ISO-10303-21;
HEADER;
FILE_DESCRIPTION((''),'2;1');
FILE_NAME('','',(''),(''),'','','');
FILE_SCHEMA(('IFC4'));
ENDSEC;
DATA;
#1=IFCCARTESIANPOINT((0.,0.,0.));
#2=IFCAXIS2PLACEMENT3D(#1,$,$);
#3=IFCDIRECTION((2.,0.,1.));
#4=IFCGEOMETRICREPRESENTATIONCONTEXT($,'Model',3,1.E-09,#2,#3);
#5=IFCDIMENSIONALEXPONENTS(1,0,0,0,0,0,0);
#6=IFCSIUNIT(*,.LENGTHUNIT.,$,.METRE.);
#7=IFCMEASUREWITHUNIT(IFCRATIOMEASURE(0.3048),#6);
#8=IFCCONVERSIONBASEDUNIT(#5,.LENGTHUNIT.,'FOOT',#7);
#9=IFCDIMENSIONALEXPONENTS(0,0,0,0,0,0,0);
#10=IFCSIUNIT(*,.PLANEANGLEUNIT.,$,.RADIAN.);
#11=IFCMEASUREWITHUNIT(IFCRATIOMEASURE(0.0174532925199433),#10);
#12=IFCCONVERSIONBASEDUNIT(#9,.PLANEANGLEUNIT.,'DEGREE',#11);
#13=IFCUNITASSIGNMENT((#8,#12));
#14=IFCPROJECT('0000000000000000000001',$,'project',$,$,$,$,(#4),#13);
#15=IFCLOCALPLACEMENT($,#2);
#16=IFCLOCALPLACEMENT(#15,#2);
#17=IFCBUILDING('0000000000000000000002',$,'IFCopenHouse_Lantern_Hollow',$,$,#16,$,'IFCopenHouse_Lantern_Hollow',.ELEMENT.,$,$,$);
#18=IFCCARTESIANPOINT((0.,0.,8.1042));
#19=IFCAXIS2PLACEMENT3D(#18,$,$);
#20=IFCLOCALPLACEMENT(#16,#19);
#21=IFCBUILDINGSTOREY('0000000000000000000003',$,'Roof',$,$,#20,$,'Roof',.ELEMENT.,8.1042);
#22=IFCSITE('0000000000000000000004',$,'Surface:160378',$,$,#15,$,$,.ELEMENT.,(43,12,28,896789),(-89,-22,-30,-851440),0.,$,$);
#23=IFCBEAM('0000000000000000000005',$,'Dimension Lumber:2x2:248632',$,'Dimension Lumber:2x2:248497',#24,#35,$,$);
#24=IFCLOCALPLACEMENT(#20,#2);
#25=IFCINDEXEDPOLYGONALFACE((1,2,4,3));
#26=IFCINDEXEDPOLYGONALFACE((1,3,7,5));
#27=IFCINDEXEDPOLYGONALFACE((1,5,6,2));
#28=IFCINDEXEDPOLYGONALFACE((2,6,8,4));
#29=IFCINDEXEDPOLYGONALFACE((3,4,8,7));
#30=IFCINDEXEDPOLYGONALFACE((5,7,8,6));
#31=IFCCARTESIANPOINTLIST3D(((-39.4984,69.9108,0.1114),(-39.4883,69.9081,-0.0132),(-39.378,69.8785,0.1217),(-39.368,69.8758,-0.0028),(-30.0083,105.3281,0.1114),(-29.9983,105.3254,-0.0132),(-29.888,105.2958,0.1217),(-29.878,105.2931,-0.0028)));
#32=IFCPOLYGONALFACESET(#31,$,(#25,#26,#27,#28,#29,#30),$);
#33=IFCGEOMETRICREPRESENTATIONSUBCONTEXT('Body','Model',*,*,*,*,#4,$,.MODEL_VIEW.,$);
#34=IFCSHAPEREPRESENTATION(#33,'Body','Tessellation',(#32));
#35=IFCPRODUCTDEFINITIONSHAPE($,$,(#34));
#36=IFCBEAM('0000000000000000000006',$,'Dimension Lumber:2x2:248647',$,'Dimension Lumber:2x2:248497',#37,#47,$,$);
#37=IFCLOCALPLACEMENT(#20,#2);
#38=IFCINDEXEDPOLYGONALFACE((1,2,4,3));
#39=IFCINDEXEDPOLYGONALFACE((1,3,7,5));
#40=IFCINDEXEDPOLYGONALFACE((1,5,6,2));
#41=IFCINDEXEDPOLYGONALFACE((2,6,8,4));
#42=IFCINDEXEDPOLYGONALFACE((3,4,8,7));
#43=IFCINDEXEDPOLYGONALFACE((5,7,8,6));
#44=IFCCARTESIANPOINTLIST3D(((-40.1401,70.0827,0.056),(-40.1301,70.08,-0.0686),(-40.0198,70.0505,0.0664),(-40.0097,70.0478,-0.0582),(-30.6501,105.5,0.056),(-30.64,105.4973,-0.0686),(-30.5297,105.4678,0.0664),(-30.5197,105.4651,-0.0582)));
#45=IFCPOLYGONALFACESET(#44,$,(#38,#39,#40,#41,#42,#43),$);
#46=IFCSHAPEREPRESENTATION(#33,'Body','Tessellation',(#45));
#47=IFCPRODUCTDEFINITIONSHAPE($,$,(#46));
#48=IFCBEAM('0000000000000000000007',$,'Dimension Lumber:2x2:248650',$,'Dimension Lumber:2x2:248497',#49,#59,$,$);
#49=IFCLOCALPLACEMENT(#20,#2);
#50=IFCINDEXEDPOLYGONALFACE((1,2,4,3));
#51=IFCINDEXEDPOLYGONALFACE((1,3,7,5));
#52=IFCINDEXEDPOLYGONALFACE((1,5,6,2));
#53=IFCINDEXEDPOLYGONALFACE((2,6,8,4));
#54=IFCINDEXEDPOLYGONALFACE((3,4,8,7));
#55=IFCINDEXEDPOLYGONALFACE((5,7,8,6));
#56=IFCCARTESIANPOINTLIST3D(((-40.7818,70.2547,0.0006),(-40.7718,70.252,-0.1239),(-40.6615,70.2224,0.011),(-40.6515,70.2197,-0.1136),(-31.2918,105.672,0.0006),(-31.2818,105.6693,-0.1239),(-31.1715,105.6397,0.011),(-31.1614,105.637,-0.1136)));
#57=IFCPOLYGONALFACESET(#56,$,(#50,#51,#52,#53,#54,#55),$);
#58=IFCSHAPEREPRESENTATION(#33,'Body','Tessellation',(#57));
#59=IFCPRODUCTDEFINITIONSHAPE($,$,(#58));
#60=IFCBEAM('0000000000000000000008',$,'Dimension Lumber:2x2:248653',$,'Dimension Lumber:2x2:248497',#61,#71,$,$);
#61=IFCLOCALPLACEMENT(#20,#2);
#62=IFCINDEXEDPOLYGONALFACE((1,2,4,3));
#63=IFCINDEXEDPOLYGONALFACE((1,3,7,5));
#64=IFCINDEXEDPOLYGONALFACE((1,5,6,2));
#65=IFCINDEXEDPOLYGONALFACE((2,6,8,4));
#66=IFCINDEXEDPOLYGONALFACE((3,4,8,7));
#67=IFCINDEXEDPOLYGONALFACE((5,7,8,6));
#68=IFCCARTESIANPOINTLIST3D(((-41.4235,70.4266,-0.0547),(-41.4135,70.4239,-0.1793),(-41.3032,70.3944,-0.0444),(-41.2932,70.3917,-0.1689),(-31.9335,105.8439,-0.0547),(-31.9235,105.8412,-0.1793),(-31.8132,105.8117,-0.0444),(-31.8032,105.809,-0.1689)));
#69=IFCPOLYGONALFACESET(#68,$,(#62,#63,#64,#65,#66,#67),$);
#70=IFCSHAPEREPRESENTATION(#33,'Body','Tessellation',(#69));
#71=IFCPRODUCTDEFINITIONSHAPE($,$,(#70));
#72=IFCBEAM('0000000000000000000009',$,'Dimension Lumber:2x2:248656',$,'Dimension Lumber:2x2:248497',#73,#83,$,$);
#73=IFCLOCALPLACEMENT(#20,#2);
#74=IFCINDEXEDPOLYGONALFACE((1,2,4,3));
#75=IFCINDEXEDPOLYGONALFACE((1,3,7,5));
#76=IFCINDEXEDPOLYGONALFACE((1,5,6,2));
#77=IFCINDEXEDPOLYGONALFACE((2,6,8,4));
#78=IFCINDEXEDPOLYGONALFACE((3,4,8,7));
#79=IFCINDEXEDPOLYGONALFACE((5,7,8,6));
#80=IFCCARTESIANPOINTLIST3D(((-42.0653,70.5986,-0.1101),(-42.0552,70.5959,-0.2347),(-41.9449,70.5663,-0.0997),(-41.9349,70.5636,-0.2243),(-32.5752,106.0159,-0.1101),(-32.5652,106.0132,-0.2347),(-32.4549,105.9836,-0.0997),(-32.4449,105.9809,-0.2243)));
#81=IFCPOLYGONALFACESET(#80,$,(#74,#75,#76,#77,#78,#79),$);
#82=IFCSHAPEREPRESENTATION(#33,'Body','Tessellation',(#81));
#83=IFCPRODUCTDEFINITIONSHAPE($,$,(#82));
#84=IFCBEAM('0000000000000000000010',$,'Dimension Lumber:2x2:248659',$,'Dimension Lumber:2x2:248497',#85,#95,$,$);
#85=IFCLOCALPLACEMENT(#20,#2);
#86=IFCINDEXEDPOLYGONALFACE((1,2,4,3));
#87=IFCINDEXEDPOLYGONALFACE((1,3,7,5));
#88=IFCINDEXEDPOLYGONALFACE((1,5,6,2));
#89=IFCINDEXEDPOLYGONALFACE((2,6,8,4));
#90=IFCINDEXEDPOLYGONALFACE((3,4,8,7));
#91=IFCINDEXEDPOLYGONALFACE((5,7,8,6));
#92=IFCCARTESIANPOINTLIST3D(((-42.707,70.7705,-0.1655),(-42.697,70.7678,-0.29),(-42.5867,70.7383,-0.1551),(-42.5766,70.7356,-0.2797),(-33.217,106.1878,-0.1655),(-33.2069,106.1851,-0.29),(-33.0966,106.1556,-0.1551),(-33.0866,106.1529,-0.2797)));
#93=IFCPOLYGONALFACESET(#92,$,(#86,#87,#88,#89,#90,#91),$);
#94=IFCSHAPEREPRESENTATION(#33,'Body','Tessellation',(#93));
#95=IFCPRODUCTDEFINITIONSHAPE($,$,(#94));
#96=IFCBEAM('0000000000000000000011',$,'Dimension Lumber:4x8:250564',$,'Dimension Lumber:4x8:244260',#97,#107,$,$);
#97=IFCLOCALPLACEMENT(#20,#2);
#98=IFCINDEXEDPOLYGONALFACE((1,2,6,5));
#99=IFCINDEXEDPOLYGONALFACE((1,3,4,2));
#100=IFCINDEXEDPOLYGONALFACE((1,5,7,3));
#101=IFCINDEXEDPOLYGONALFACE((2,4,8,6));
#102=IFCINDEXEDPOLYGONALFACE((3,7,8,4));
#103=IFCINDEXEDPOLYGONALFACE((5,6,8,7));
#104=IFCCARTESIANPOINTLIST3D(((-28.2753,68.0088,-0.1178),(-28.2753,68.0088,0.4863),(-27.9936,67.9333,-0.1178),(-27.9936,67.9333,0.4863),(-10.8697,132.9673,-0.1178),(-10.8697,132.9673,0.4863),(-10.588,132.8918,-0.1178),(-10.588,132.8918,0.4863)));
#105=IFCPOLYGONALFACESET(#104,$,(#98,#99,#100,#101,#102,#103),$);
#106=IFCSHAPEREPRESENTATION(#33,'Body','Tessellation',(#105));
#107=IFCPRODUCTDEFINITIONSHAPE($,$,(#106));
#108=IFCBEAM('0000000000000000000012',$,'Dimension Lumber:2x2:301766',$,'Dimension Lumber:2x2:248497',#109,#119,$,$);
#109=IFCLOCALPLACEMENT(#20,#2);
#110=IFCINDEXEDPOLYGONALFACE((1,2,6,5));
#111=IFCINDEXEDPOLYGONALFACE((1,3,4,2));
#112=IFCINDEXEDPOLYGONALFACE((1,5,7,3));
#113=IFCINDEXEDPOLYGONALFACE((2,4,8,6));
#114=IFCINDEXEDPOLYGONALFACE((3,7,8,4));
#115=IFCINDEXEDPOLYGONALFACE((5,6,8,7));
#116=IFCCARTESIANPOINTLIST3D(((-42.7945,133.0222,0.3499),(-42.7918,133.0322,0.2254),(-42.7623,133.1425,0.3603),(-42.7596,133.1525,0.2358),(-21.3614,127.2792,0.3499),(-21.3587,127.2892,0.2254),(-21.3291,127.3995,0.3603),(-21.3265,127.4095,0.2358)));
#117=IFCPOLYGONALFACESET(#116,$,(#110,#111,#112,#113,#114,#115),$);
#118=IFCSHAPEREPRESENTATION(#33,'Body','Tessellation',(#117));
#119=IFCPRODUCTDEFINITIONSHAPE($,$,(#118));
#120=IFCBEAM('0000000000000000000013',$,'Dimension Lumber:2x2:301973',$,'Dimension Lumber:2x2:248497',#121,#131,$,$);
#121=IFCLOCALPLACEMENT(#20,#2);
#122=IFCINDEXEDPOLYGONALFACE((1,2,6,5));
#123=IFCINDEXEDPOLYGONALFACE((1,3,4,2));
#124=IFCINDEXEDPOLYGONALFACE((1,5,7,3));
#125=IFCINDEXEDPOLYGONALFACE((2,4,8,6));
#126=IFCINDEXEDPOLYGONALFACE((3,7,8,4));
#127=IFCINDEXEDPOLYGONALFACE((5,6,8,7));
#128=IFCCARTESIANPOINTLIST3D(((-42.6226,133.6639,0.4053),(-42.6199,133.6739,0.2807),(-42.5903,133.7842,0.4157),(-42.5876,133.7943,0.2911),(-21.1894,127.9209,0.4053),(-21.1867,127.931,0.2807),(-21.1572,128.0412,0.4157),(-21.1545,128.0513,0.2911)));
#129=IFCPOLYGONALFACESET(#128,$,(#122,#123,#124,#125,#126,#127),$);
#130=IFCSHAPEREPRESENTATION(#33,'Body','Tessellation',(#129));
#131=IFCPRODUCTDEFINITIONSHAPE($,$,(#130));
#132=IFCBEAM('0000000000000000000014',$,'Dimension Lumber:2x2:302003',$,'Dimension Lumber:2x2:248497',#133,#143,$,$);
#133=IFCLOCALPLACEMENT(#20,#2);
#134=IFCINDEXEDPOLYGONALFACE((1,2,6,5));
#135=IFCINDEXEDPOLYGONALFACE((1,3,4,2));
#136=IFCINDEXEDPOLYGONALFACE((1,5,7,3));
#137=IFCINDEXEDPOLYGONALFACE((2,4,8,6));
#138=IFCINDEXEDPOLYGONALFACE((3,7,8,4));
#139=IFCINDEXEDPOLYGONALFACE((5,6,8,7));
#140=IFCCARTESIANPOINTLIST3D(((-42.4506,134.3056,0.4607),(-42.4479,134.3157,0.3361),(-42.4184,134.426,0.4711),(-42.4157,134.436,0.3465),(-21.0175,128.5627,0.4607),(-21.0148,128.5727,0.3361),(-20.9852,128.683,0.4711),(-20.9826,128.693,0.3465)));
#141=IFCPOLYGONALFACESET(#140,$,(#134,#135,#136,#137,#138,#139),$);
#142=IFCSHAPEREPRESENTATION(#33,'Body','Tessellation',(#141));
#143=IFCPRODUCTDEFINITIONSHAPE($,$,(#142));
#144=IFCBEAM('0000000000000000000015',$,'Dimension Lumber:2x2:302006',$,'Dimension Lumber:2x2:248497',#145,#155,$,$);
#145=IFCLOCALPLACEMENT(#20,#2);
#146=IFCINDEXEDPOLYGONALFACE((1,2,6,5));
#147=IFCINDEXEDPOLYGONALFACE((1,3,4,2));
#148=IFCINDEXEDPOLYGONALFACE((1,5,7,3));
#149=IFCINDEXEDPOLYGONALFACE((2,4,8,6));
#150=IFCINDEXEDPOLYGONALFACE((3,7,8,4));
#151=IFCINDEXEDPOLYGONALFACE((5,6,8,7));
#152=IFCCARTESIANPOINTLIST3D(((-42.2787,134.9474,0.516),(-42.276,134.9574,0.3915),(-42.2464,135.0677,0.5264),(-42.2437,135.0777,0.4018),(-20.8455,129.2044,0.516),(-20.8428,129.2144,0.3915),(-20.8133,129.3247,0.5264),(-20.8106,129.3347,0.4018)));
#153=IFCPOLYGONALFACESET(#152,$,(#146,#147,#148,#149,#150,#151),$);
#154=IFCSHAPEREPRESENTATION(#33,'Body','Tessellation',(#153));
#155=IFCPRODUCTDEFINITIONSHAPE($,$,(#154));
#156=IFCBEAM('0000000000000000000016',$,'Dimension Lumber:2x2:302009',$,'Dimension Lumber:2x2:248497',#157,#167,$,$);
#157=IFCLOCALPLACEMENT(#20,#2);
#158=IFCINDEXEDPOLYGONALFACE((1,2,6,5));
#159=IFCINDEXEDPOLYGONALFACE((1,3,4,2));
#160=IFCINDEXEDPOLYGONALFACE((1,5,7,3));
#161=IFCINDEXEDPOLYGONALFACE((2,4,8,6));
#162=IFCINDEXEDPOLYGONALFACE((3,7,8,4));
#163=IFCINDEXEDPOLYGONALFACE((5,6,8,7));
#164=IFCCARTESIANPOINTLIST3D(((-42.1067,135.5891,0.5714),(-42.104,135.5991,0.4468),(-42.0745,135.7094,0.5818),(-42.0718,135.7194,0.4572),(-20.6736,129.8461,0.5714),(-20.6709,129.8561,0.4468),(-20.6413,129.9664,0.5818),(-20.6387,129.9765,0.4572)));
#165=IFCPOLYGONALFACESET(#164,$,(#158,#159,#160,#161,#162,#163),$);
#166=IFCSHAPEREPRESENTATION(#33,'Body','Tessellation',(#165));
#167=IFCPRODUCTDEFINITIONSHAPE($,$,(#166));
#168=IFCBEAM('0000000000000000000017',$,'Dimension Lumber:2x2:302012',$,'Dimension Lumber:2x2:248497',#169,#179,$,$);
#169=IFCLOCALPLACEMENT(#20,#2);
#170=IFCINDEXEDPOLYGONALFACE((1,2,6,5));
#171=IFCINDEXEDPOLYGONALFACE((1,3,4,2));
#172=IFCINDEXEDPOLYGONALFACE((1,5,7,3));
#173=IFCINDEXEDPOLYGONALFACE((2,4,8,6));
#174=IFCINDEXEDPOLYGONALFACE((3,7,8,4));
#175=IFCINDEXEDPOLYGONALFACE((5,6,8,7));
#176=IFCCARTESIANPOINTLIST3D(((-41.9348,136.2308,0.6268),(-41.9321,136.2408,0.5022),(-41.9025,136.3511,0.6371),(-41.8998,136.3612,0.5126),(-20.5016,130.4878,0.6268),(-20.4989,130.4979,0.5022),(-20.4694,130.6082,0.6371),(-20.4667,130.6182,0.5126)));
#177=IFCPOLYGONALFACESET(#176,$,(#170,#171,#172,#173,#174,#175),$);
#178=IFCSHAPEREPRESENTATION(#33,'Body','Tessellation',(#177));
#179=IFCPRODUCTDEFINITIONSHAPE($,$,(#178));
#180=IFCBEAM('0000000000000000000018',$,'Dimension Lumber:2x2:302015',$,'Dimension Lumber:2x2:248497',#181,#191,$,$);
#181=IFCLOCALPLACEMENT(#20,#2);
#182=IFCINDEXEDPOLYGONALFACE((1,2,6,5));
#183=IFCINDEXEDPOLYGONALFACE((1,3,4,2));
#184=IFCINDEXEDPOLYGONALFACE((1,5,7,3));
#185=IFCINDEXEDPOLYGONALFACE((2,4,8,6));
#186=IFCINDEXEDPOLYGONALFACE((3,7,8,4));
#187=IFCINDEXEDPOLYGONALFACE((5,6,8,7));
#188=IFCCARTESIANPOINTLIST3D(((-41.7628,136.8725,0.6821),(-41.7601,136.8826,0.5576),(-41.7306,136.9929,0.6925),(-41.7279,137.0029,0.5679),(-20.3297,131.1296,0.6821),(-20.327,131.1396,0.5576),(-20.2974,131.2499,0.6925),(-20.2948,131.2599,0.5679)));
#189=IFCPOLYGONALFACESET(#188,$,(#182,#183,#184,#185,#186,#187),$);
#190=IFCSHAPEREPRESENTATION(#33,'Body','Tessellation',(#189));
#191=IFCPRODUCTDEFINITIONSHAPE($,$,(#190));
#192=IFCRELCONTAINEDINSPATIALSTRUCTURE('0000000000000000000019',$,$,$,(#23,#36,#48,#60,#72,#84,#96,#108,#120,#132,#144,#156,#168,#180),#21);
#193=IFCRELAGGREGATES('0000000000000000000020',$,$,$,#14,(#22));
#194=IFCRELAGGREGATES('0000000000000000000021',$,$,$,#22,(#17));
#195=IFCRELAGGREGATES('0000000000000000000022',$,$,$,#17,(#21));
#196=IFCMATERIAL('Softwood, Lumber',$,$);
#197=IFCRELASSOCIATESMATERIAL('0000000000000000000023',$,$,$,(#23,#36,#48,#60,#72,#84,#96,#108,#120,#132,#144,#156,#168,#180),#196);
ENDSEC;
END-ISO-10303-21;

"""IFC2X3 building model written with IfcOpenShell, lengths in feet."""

from ifc_helpers import new_model, entity, si_unit, converted_unit, direction, frame, frame_2d, origin, place, context, subcontext, project, spatial, rectangle, extrude, material, element, save


model = new_model("IFC2X3")

# Units and contexts
model_context = context("Model", 3, precision=1e-09, world=origin(), true_north=direction((2.0, 0.0, 1.0)))
body_context = subcontext(model_context, "Body", "Model", "MODEL_VIEW")
ifc_project = project(units=[converted_unit("LENGTHUNIT", "FOOT", entity("IfcRatioMeasure", 0.3048), si_unit("LENGTHUNIT", "METRE"), dimensions=[1, 0, 0, 0, 0, 0, 0]), converted_unit("PLANEANGLEUNIT", "DEGREE", entity("IfcRatioMeasure", 0.0174532925199433), si_unit("PLANEANGLEUNIT", "RADIAN"), dimensions=[0, 0, 0, 0, 0, 0, 0])], contexts=[model_context])

# Site, building, storey
site_placement = place(None, origin())
site = spatial("IfcSite", under=ifc_project, at=site_placement, Name="Surface:160378", CompositionType="ELEMENT", RefLatitude=(43, 12, 28, 896789), RefLongitude=(-89, -22, -30, -851440), RefElevation=0.0)
building_placement = place(site_placement, origin())
building = spatial("IfcBuilding", under=site, at=building_placement, Name="IFCopenHouse_Lantern_Hollow", LongName="IFCopenHouse_Lantern_Hollow", CompositionType="ELEMENT")
storey_placement = place(building_placement, frame((0.0, 0.0, 8.1042)))
storey = spatial("IfcBuildingStorey", under=building, at=storey_placement, Name="Roof", LongName="Roof", CompositionType="ELEMENT", Elevation=8.1042)

# Beams
ifc_material_1 = material(Name="Softwood, Lumber")
beam_1_placement = place(storey_placement, frame((-39.4382, 69.8947, 0.1165), z_axis=(0.0, 0.0, 1.0), x_axis=(0.258819, 0.965926, 0.0)))
element("IfcBeam", 1, at=beam_1_placement, inside=storey, material=ifc_material_1, Name="Dimension Lumber:2x2:248632", ObjectType="Dimension Lumber:2x2:248497", context=body_context, shape_type="SweptSolid", body=[
    extrude(rectangle(XDim=0.125, YDim=0.125, at=frame_2d((0.0, 0.0), x_axis=(0.0, 1.0))), frame((0.0, -0.0052, -0.0623), z_axis=(1.0, 0.0, 0.0), x_axis=(0.0, -0.996546, 0.083045)), (0.0, 0.0, 1.0), 36.6667),
])
beam_2_placement = place(storey_placement, frame((-40.0799, 70.0666, 0.0612), z_axis=(0.0, 0.0, 1.0), x_axis=(0.258819, 0.965926, 0.0)))
element("IfcBeam", 2, at=beam_2_placement, inside=storey, material=ifc_material_1, Name="Dimension Lumber:2x2:248647", ObjectType="Dimension Lumber:2x2:248497", context=body_context, shape_type="SweptSolid", body=[
    extrude(rectangle(XDim=0.125, YDim=0.125, at=frame_2d((0.0, 0.0), x_axis=(0.0, 1.0))), frame((0.0, -0.0052, -0.0623), z_axis=(1.0, 0.0, 0.0), x_axis=(0.0, -0.996546, 0.083045)), (0.0, 0.0, 1.0), 36.6667),
])
beam_3_placement = place(storey_placement, frame((-40.7217, 70.2386, 0.0058), z_axis=(0.0, 0.0, 1.0), x_axis=(0.258819, 0.965926, 0.0)))
element("IfcBeam", 3, at=beam_3_placement, inside=storey, material=ifc_material_1, Name="Dimension Lumber:2x2:248650", ObjectType="Dimension Lumber:2x2:248497", context=body_context, shape_type="SweptSolid", body=[
    extrude(rectangle(XDim=0.125, YDim=0.125, at=frame_2d((0.0, 0.0), x_axis=(0.0, 1.0))), frame((0.0, -0.0052, -0.0623), z_axis=(1.0, 0.0, 0.0), x_axis=(0.0, -0.996546, 0.083045)), (0.0, 0.0, 1.0), 36.6667),
])
beam_4_placement = place(storey_placement, frame((-41.3634, 70.4105, -0.0495), z_axis=(0.0, 0.0, 1.0), x_axis=(0.258819, 0.965926, 0.0)))
element("IfcBeam", 4, at=beam_4_placement, inside=storey, material=ifc_material_1, Name="Dimension Lumber:2x2:248653", ObjectType="Dimension Lumber:2x2:248497", context=body_context, shape_type="SweptSolid", body=[
    extrude(rectangle(XDim=0.125, YDim=0.125, at=frame_2d((0.0, 0.0), x_axis=(0.0, 1.0))), frame((0.0, -0.0052, -0.0623), z_axis=(1.0, 0.0, 0.0), x_axis=(0.0, -0.996546, 0.083045)), (0.0, 0.0, 1.0), 36.6667),
])
beam_5_placement = place(storey_placement, frame((-42.0051, 70.5825, -0.1049), z_axis=(0.0, 0.0, 1.0), x_axis=(0.258819, 0.965926, 0.0)))
element("IfcBeam", 5, at=beam_5_placement, inside=storey, material=ifc_material_1, Name="Dimension Lumber:2x2:248656", ObjectType="Dimension Lumber:2x2:248497", context=body_context, shape_type="SweptSolid", body=[
    extrude(rectangle(XDim=0.125, YDim=0.125, at=frame_2d((0.0, 0.0), x_axis=(0.0, 1.0))), frame((0.0, -0.0052, -0.0623), z_axis=(1.0, 0.0, 0.0), x_axis=(0.0, -0.996546, 0.083045)), (0.0, 0.0, 1.0), 36.6667),
])
beam_6_placement = place(storey_placement, frame((-42.6468, 70.7544, -0.1603), z_axis=(0.0, 0.0, 1.0), x_axis=(0.258819, 0.965926, 0.0)))
element("IfcBeam", 6, at=beam_6_placement, inside=storey, material=ifc_material_1, Name="Dimension Lumber:2x2:248659", ObjectType="Dimension Lumber:2x2:248497", context=body_context, shape_type="SweptSolid", body=[
    extrude(rectangle(XDim=0.125, YDim=0.125, at=frame_2d((0.0, 0.0), x_axis=(0.0, 1.0))), frame((0.0, -0.0052, -0.0623), z_axis=(1.0, 0.0, 0.0), x_axis=(0.0, -0.996546, 0.083045)), (0.0, 0.0, 1.0), 36.6667),
])
beam_7_placement = place(storey_placement, frame((-10.7288, 132.9295, -0.1178), z_axis=(0.0, 0.0, 1.0), x_axis=(-0.258819, -0.965926, 0.0)))
element("IfcBeam", 7, at=beam_7_placement, inside=storey, material=ifc_material_1, Name="Dimension Lumber:4x8:250564", ObjectType="Dimension Lumber:4x8:244260", context=body_context, shape_type="SweptSolid", body=[
    extrude(rectangle(XDim=0.6042, YDim=0.2917, at=frame_2d((0.0, 0.0), x_axis=(1.0, 0.0))), frame((0.0, 0.0, 0.3021), z_axis=(1.0, 0.0, 0.0), x_axis=(0.0, 0.0, -1.0)), (0.0, 0.0, 1.0), 67.25),
])
beam_8_placement = place(storey_placement, frame((-21.3453, 127.3394, 0.3551), z_axis=(0.0, 0.0, 1.0), x_axis=(-0.965926, 0.258819, 0.0)))
element("IfcBeam", 8, at=beam_8_placement, inside=storey, material=ifc_material_1, Name="Dimension Lumber:2x2:301766", ObjectType="Dimension Lumber:2x2:248497", context=body_context, shape_type="SweptSolid", body=[
    extrude(rectangle(XDim=0.125, YDim=0.125, at=frame_2d((0.0, 0.0), x_axis=(0.0, 1.0))), frame((0.0, -0.0052, -0.0623), z_axis=(1.0, 0.0, 0.0), x_axis=(0.0, -0.996546, 0.083045)), (0.0, 0.0, 1.0), 22.1892),
])
beam_9_placement = place(storey_placement, frame((-21.1733, 127.9811, 0.4105), z_axis=(0.0, 0.0, 1.0), x_axis=(-0.965926, 0.258819, 0.0)))
element("IfcBeam", 9, at=beam_9_placement, inside=storey, material=ifc_material_1, Name="Dimension Lumber:2x2:301973", ObjectType="Dimension Lumber:2x2:248497", context=body_context, shape_type="SweptSolid", body=[
    extrude(rectangle(XDim=0.125, YDim=0.125, at=frame_2d((0.0, 0.0), x_axis=(0.0, 1.0))), frame((0.0, -0.0052, -0.0623), z_axis=(1.0, 0.0, 0.0), x_axis=(0.0, -0.996546, 0.083045)), (0.0, 0.0, 1.0), 22.1892),
])
beam_10_placement = place(storey_placement, frame((-21.0014, 128.6228, 0.4659), z_axis=(0.0, 0.0, 1.0), x_axis=(-0.965926, 0.258819, 0.0)))
element("IfcBeam", 10, at=beam_10_placement, inside=storey, material=ifc_material_1, Name="Dimension Lumber:2x2:302003", ObjectType="Dimension Lumber:2x2:248497", context=body_context, shape_type="SweptSolid", body=[
    extrude(rectangle(XDim=0.125, YDim=0.125, at=frame_2d((0.0, 0.0), x_axis=(0.0, 1.0))), frame((0.0, -0.0052, -0.0623), z_axis=(1.0, 0.0, 0.0), x_axis=(0.0, -0.996546, 0.083045)), (0.0, 0.0, 1.0), 22.1892),
])
for number, where, z_axis, x_axis, name in (
    (11, (-20.8294, 129.2645, 0.5212), (0.0, 0.0, 1.0), (-0.965926, 0.258819, 0.0), "Dimension Lumber:2x2:302006"),
    (12, (-20.6575, 129.9063, 0.5766), (0.0, 0.0, 1.0), (-0.965926, 0.258819, 0.0), "Dimension Lumber:2x2:302009"),
    (13, (-20.4855, 130.548, 0.632), (0.0, 0.0, 1.0), (-0.965926, 0.258819, 0.0), "Dimension Lumber:2x2:302012"),
    (14, (-20.3136, 131.1897, 0.6873), (0.0, 0.0, 1.0), (-0.965926, 0.258819, 0.0), "Dimension Lumber:2x2:302015"),
):
    element("IfcBeam", number, at=place(storey_placement, frame(where, z_axis=z_axis, x_axis=x_axis)), inside=storey, material=ifc_material_1, Name=name, ObjectType="Dimension Lumber:2x2:248497", context=body_context, shape_type="SweptSolid", body=[
        extrude(rectangle(XDim=0.125, YDim=0.125, at=frame_2d((0.0, 0.0), x_axis=(0.0, 1.0))), frame((0.0, -0.0052, -0.0623), z_axis=(1.0, 0.0, 0.0), x_axis=(0.0, -0.996546, 0.083045)), (0.0, 0.0, 1.0), 22.1892),
    ])

save(model, "model.ifc")
